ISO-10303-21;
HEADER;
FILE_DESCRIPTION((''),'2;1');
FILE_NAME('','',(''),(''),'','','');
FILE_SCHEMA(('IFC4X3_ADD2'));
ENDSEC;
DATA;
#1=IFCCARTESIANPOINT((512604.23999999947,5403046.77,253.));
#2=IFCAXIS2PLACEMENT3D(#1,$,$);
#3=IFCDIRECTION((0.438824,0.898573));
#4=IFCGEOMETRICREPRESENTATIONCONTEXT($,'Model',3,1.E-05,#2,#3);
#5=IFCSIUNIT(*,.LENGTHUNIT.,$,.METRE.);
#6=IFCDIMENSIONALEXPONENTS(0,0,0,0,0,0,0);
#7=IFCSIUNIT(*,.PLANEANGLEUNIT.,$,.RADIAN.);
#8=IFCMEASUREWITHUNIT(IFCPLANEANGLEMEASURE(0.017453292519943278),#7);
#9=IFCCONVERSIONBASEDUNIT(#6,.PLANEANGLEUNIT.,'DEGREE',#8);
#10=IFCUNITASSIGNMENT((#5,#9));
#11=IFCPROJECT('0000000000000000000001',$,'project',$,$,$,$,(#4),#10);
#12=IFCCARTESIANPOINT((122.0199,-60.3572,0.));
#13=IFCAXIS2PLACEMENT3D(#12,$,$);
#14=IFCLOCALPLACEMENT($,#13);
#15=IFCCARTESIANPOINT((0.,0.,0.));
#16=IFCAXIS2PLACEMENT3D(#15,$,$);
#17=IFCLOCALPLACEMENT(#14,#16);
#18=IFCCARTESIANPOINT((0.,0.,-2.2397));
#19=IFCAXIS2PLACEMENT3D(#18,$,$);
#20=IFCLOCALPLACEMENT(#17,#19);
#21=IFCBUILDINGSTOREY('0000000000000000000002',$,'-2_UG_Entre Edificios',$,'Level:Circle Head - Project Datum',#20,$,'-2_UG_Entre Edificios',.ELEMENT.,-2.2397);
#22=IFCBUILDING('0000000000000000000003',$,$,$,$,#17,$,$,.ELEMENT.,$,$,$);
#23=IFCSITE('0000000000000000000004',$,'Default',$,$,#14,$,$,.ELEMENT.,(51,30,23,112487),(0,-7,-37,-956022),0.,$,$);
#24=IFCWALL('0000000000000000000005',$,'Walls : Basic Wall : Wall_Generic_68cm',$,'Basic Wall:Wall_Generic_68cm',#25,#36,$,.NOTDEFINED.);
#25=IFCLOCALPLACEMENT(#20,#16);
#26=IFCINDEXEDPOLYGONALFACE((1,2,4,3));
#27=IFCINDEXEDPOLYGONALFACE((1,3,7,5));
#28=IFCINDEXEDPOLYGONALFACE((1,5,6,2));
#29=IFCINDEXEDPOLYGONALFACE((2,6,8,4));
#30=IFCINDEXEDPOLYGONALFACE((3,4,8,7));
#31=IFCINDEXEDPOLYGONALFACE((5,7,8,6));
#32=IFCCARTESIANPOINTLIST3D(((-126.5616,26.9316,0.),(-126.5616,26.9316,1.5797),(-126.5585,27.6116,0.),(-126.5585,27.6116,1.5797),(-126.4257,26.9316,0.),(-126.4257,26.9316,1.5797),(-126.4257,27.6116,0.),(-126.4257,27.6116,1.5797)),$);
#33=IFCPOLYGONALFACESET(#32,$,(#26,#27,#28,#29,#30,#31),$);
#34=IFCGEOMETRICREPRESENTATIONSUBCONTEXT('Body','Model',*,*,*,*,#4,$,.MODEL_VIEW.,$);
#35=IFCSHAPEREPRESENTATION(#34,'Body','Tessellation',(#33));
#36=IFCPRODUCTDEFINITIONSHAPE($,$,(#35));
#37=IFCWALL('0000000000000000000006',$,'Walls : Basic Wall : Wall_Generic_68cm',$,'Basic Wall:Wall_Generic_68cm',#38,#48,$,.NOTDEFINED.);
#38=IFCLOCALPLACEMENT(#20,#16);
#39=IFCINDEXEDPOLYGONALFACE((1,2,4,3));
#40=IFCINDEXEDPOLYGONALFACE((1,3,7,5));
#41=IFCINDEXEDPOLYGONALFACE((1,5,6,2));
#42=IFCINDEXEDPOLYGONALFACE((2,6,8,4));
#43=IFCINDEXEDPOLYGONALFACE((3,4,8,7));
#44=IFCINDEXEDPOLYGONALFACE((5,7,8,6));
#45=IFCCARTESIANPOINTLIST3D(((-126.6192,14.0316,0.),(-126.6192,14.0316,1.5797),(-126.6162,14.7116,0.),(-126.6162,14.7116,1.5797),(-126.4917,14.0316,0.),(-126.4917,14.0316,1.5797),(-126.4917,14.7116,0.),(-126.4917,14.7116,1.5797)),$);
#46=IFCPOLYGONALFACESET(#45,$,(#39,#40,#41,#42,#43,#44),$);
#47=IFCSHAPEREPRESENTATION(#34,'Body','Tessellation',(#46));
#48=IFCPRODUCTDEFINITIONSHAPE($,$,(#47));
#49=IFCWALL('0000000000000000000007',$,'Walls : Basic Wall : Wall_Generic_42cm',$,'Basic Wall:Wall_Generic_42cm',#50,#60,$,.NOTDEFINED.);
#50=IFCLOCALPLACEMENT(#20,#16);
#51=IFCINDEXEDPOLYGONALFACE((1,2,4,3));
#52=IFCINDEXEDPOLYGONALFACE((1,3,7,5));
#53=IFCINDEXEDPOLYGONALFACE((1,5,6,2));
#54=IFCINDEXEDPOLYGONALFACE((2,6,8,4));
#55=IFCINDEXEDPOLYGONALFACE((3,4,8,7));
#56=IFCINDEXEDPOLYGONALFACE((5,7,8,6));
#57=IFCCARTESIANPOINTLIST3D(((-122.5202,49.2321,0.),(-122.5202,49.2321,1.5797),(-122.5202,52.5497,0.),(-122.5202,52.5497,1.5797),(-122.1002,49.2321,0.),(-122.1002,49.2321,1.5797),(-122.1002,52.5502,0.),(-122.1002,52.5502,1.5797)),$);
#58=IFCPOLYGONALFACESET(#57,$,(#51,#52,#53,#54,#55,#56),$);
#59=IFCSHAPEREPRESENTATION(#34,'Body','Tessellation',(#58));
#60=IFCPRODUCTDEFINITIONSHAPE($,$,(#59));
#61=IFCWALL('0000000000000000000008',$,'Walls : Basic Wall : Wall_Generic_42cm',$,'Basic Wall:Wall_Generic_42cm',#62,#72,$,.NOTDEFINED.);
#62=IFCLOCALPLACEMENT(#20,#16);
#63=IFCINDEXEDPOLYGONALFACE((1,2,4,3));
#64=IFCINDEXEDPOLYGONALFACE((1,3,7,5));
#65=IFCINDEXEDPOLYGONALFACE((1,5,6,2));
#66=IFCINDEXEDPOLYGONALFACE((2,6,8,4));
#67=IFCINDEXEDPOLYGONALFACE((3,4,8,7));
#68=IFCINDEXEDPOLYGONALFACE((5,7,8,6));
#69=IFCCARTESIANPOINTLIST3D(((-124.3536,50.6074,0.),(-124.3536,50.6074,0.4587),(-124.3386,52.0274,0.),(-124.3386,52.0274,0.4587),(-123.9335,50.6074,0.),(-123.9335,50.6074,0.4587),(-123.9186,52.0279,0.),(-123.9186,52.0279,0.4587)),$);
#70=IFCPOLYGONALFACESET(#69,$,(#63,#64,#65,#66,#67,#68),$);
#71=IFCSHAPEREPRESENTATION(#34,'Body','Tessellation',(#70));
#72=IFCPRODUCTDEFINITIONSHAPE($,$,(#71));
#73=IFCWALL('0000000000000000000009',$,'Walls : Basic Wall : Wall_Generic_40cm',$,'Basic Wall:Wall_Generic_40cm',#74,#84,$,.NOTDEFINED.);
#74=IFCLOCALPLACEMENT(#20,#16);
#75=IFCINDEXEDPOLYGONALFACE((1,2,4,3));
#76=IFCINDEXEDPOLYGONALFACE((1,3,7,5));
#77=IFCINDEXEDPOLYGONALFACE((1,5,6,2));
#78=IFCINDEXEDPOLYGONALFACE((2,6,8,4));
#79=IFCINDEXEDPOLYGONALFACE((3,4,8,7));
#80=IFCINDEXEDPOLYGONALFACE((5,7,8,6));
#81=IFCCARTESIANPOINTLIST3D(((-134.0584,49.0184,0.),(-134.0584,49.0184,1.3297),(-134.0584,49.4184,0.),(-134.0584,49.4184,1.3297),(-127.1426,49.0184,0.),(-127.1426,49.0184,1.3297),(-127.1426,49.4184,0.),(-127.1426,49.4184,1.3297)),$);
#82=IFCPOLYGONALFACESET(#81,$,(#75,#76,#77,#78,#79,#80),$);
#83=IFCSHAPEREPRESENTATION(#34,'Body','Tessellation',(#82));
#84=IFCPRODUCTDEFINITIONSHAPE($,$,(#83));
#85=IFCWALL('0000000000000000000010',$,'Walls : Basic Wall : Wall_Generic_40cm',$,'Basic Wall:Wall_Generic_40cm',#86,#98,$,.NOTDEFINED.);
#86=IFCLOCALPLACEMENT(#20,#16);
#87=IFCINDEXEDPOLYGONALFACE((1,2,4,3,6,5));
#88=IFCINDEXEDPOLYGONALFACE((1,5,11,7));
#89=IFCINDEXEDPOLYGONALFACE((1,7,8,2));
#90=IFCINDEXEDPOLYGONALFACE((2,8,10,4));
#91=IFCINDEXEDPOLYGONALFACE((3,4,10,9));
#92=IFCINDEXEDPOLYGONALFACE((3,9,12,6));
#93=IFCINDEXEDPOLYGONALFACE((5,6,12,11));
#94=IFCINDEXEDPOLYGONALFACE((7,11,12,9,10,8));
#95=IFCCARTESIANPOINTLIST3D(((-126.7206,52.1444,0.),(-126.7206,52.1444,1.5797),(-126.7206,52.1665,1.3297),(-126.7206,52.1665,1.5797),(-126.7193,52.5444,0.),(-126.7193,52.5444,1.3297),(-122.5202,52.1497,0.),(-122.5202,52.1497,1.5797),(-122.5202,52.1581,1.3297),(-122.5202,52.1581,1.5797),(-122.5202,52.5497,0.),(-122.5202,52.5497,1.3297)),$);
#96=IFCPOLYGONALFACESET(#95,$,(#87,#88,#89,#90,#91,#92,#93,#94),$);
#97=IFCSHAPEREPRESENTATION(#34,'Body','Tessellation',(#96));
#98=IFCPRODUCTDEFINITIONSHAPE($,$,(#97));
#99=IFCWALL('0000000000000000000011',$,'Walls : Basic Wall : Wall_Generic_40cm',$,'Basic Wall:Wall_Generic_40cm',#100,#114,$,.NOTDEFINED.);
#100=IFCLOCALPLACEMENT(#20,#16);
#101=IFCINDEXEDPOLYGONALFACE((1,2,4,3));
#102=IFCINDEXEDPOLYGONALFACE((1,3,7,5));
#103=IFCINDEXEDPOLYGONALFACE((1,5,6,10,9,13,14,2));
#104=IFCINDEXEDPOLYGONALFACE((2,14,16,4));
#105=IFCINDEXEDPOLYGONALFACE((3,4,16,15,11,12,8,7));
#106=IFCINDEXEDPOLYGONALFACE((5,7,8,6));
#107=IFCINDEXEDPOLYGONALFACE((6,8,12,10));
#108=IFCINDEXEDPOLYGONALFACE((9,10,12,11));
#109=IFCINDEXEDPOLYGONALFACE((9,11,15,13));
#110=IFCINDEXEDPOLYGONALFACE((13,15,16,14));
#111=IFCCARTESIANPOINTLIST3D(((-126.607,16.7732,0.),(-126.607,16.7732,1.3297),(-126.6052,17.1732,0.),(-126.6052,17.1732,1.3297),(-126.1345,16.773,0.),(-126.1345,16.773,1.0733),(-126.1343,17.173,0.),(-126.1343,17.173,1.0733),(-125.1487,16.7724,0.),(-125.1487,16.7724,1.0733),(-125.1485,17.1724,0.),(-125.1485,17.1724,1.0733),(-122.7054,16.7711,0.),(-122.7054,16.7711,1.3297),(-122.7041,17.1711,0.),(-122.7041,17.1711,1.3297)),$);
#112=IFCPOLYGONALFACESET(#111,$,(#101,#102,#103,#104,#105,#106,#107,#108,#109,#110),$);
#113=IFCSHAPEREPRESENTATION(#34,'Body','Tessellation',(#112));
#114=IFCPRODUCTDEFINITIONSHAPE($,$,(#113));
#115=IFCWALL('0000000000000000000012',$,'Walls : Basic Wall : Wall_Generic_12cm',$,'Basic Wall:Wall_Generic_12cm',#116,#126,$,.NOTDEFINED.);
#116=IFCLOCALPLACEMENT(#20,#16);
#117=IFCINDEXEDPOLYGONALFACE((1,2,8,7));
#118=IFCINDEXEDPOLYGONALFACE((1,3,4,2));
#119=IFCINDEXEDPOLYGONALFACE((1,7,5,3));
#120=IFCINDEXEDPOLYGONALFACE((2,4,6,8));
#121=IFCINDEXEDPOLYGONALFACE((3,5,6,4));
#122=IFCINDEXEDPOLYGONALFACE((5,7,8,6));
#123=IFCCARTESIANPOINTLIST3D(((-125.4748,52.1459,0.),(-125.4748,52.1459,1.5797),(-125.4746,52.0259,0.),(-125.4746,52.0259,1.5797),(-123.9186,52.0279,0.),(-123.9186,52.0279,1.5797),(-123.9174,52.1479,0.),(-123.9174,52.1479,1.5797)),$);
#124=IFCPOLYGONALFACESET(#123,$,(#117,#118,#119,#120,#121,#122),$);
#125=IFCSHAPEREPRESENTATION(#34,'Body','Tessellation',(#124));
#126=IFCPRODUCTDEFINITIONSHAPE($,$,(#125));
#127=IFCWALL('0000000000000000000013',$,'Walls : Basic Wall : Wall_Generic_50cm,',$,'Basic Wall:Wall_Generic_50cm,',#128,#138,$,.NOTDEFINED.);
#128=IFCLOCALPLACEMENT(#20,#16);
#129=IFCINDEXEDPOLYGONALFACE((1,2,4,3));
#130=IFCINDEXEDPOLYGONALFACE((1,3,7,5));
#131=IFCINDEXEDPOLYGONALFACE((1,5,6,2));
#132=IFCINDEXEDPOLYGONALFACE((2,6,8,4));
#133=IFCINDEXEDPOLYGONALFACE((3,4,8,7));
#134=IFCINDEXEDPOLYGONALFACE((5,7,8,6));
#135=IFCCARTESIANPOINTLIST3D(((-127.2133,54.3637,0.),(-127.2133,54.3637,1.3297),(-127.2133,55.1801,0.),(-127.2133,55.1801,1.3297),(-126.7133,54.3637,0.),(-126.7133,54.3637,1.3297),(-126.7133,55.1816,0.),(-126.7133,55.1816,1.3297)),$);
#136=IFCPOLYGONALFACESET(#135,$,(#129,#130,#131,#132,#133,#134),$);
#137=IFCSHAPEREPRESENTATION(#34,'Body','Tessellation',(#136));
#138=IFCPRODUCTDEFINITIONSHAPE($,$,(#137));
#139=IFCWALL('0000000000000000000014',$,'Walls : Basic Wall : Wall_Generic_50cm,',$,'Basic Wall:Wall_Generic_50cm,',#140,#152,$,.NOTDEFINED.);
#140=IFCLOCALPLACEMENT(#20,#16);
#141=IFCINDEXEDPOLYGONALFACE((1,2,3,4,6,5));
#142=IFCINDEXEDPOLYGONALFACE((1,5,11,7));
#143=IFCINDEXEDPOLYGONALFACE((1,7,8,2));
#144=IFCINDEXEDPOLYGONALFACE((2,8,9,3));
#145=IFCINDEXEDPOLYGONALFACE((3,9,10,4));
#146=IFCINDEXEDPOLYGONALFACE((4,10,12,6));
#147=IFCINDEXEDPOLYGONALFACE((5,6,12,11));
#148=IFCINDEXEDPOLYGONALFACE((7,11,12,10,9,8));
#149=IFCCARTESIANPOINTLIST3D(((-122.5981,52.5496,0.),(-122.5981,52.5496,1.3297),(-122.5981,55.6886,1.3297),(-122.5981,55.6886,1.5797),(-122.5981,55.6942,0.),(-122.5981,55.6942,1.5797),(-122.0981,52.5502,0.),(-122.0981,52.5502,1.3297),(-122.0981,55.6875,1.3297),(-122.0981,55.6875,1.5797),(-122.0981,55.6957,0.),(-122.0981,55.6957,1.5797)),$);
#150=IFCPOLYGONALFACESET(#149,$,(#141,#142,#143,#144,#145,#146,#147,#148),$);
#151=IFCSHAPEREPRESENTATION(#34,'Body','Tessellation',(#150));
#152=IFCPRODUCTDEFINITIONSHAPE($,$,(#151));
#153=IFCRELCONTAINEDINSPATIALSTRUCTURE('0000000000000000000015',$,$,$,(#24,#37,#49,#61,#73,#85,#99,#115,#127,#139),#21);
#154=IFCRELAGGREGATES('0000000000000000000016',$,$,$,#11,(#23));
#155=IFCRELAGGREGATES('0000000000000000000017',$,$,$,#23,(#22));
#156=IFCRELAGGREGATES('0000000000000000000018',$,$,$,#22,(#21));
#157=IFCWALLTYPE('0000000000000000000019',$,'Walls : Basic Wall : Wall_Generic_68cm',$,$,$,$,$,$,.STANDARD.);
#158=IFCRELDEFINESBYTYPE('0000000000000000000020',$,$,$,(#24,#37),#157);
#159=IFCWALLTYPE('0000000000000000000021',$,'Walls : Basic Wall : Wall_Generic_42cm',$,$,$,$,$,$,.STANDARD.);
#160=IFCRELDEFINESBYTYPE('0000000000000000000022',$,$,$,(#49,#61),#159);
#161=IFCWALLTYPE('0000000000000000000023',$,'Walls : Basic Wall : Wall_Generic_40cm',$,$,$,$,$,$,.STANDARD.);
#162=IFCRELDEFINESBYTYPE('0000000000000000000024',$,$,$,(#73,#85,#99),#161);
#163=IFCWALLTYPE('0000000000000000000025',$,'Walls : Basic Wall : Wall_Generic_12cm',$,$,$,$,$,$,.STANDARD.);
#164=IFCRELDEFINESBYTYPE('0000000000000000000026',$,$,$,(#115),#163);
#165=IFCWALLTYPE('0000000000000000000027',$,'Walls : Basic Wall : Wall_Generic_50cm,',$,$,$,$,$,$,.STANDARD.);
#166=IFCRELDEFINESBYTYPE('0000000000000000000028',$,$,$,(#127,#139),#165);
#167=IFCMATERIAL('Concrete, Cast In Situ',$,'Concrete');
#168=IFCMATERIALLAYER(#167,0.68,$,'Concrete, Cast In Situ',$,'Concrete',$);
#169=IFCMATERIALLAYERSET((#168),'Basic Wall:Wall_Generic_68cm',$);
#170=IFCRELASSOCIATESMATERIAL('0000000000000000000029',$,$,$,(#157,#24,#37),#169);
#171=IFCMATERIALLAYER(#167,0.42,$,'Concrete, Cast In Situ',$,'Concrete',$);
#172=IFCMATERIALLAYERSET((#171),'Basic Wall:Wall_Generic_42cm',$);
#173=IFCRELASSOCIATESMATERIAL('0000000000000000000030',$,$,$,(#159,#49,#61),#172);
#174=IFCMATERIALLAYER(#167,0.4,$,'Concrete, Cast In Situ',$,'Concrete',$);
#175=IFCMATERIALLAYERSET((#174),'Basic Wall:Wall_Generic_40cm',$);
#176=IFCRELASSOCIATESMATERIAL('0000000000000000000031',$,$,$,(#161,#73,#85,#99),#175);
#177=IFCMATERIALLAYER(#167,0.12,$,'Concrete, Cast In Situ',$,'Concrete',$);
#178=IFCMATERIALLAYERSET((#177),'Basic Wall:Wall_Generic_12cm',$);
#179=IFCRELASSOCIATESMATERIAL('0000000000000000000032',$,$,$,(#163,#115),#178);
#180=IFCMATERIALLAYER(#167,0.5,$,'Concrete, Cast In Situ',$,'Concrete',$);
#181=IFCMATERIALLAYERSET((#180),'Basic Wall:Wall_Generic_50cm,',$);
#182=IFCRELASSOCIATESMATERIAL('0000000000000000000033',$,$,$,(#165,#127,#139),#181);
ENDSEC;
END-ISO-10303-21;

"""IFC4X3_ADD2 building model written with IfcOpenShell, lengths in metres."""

from ifc_helpers import new_model, entity, si_unit, converted_unit, direction, frame, frame_2d, origin, place, context, subcontext, project, spatial, polyline, rectangle, outline, extrude, clip, halfspace, bounded_halfspace, material, layer, layer_set, type_object, element, save


model = new_model("IFC4X3_ADD2")

# Units and contexts
model_context = context("Model", 3, precision=1e-05, world=frame((512604.23999999947, 5403046.77, 253.0)), true_north=direction((0.438824, 0.898573)))
body_context = subcontext(model_context, "Body", "Model", "MODEL_VIEW")
ifc_project = project(units=[si_unit("LENGTHUNIT", "METRE"), converted_unit("PLANEANGLEUNIT", "DEGREE", entity("IfcPlaneAngleMeasure", 0.017453292519943278), si_unit("PLANEANGLEUNIT", "RADIAN"), dimensions=[0, 0, 0, 0, 0, 0, 0])], contexts=[model_context])

# Site, building, storey
site_placement = place(None, frame((122.0199, -60.3572, 0.0)))
site = spatial("IfcSite", under=ifc_project, at=site_placement, Name="Default", CompositionType="ELEMENT", RefLatitude=(51, 30, 23, 112487), RefLongitude=(0, -7, -37, -956022), RefElevation=0.0)
building_placement = place(site_placement, origin())
building = spatial("IfcBuilding", under=site, at=building_placement, CompositionType="ELEMENT")
storey_placement = place(building_placement, frame((0.0, 0.0, -2.2397)))
storey = spatial("IfcBuildingStorey", under=building, at=storey_placement, Name="-2_UG_Entre Edificios", ObjectType="Level:Circle Head - Project Datum", LongName="-2_UG_Entre Edificios", CompositionType="ELEMENT", Elevation=-2.2397)

# Walls
ifc_material_1 = material(Name="Concrete, Cast In Situ", Category="Concrete")
ifc_layer_1 = layer(ifc_material_1, 0.68, Name="Concrete, Cast In Situ", Category="Concrete")
ifc_layer_set_1 = layer_set([ifc_layer_1], Name="Basic Wall:Wall_Generic_68cm")
wall_type_1 = type_object("IfcWallType", Name="Walls : Basic Wall : Wall_Generic_68cm", PredefinedType="STANDARD", material=ifc_layer_set_1)
wall_1_placement = place(storey_placement, frame((-126.5616, 27.2716, 0.0)))
element("IfcWall", 1, at=wall_1_placement, inside=storey, type_object=wall_type_1, material=ifc_layer_set_1, Name="Walls : Basic Wall : Wall_Generic_68cm", ObjectType="Basic Wall:Wall_Generic_68cm", PredefinedType="NOTDEFINED", context=body_context, shape_type="Clipping", body=[
    clip(extrude(outline(polyline([(0.1359, -0.34), (0.1359, 0.34), (0.003, 0.34), (0.0, -0.34), (0.1359, -0.34)])), origin(), (0.0, 0.0, 1.0), 1.5797), halfspace(frame((0.0, 0.0, -1.0603)), True)),
])
wall_2_placement = place(storey_placement, frame((-126.6192, 14.3716, 0.0)))
element("IfcWall", 2, at=wall_2_placement, inside=storey, type_object=wall_type_1, material=ifc_layer_set_1, Name="Walls : Basic Wall : Wall_Generic_68cm", ObjectType="Basic Wall:Wall_Generic_68cm", PredefinedType="NOTDEFINED", context=body_context, shape_type="Clipping", body=[
    clip(extrude(outline(polyline([(0.1275, -0.34), (0.1275, 0.34), (0.003, 0.34), (0.0, -0.34), (0.1275, -0.34)])), origin(), (0.0, 0.0, 1.0), 1.5797), halfspace(frame((0.0, 0.0, -1.0603)), True)),
])
ifc_layer_2 = layer(ifc_material_1, 0.42, Name="Concrete, Cast In Situ", Category="Concrete")
ifc_layer_set_2 = layer_set([ifc_layer_2], Name="Basic Wall:Wall_Generic_42cm")
wall_type_2 = type_object("IfcWallType", Name="Walls : Basic Wall : Wall_Generic_42cm", PredefinedType="STANDARD", material=ifc_layer_set_2)
wall_3_placement = place(storey_placement, frame((-122.3102, 49.2321, 0.0), z_axis=(0.0, 0.0, 1.0), x_axis=(0.0, 1.0, 0.0)))
element("IfcWall", 3, at=wall_3_placement, inside=storey, type_object=wall_type_2, material=ifc_layer_set_2, Name="Walls : Basic Wall : Wall_Generic_42cm", ObjectType="Basic Wall:Wall_Generic_42cm", PredefinedType="NOTDEFINED", context=body_context, shape_type="Clipping", body=[
    clip(extrude(outline(polyline([(3.3182, -0.21), (3.3176, 0.21), (2.9176, 0.21), (0.0, 0.21), (0.0, -0.2064), (0.0, -0.21), (3.3182, -0.21)])), origin(), (0.0, 0.0, 1.0), 1.5797), halfspace(frame((0.0, 0.0, -1.0603)), True)),
])
wall_4_placement = place(storey_placement, frame((-124.1286, 52.0301, 0.0), z_axis=(0.0, 0.0, 1.0), x_axis=(-0.010506, -0.999945, 0.0)))
element("IfcWall", 4, at=wall_4_placement, inside=storey, type_object=wall_type_2, material=ifc_layer_set_2, Name="Walls : Basic Wall : Wall_Generic_42cm", ObjectType="Basic Wall:Wall_Generic_42cm", PredefinedType="NOTDEFINED", context=body_context, shape_type="Clipping", body=[
    clip(extrude(outline(polyline([(1.425, -0.21), (1.4206, 0.21), (1.1142, 0.21), (0.0, 0.21), (0.0049, -0.21), (1.165, -0.21), (1.425, -0.21)])), origin(), (0.0, 0.0, 1.0), 0.4587), halfspace(frame((0.0, 0.0, -1.0603)), True)),
])
ifc_layer_3 = layer(ifc_material_1, 0.4, Name="Concrete, Cast In Situ", Category="Concrete")
ifc_layer_set_3 = layer_set([ifc_layer_3], Name="Basic Wall:Wall_Generic_40cm")
wall_type_3 = type_object("IfcWallType", Name="Walls : Basic Wall : Wall_Generic_40cm", PredefinedType="STANDARD", material=ifc_layer_set_3)
wall_5_placement = place(storey_placement, frame((-127.1426, 49.2184, 0.0), z_axis=(0.0, 0.0, 1.0), x_axis=(-1.0, 0.0, 0.0)))
element("IfcWall", 5, at=wall_5_placement, inside=storey, type_object=wall_type_3, material=ifc_layer_set_3, Name="Walls : Basic Wall : Wall_Generic_40cm", ObjectType="Basic Wall:Wall_Generic_40cm", PredefinedType="NOTDEFINED", context=body_context, shape_type="SweptSolid", body=[
    extrude(rectangle(XDim=0.4, YDim=6.9158, at=frame_2d((0.0, 0.0), x_axis=(1.0, 0.0))), frame((3.4579, 0.0, 0.0), z_axis=(0.0, 0.0, 1.0), x_axis=(0.0, 1.0, 0.0)), (0.0, 0.0, 1.0), 1.3297),
])
wall_6_placement = place(storey_placement, frame((-126.7209, 52.3444, 0.0), z_axis=(0.0, 0.0, 1.0), x_axis=(0.999999, 0.001273, 0.0)))
element("IfcWall", 6, at=wall_6_placement, inside=storey, type_object=wall_type_3, material=ifc_layer_set_3, Name="Walls : Basic Wall : Wall_Generic_40cm", ObjectType="Basic Wall:Wall_Generic_40cm", PredefinedType="NOTDEFINED", context=body_context, shape_type="Clipping", body=[
    clip(clip(extrude(outline(polyline([(0.0018, 0.2), (0.0, -0.2), (1.2459, -0.2), (2.8033, -0.2), (3.0403, -0.2), (4.2005, -0.2), (4.201, 0.2), (4.1231, 0.2), (0.0018, 0.2)])), origin(), (0.0, 0.0, 1.0), 1.5797), bounded_halfspace(frame((4.2005, -0.1916, 1.3297), z_axis=(0.0, 0.0, -1.0), x_axis=(0.999999, -0.001273, 0.0)), True, frame((4.2005, -0.1916, 1.3297)), polyline([(0.0, 0.0), (0.0005, 0.3916), (-0.0774, 0.3916), (-4.1986, 0.3916), (-4.2004, 0.0138), (-2.9647, 0.0097), (0.0, 0.0)]))), halfspace(frame((0.0, 0.0, -1.0603)), True)),
])

# Wall, opening
wall_7_placement = place(storey_placement, frame((-126.6069, 16.9732, 0.0), z_axis=(0.0, 0.0, 1.0), x_axis=(1.0, -0.000544, 0.0)))
wall_7 = element("IfcWall", 7, at=wall_7_placement, inside=storey, type_object=wall_type_3, material=ifc_layer_set_3, Name="Walls : Basic Wall : Wall_Generic_40cm", ObjectType="Basic Wall:Wall_Generic_40cm", PredefinedType="NOTDEFINED", context=body_context, shape_type="Clipping", body=[
    clip(clip(extrude(outline(polyline([(0.0, -0.2), (3.9016, -0.2), (3.9027, 0.2), (0.0016, 0.2), (0.0, -0.2)])), origin(), (0.0, 0.0, 1.0), 1.3297), bounded_halfspace(frame((0.0, -0.2, 1.3297), z_axis=(0.0, 0.0, -1.0), x_axis=(1.0, 0.000544, 0.0)), True, frame((0.0, -0.2, 1.3297)), polyline([(0.0, 0.0), (3.9016, 0.0), (3.9027, 0.4), (0.0016, 0.4), (0.0, 0.0)]))), halfspace(frame((0.0, 0.0, -1.0603)), True)),
])
opening_placement = place(wall_7_placement, frame((126.6161, -16.9044, -1.0603), z_axis=(0.0, 0.0, 1.0), x_axis=(1.0, 0.000544, 0.0)))
element("IfcOpeningElement", 8, at=opening_placement, cuts=wall_7, PredefinedType="OPENING", context=body_context, shape_type="SweptSolid", body=[
    extrude(rectangle(XDim=2.1336, YDim=0.9858, at=frame_2d((0.0, 0.0), x_axis=(0.0, 1.0))), frame((-125.6416, 16.7727, 1.0668), z_axis=(0.000544, 1.0, 0.0), x_axis=(1.0, -0.000544, 0.0)), (0.0, 0.0, 1.0), 0.4),
])

# Walls
ifc_layer_4 = layer(ifc_material_1, 0.12, Name="Concrete, Cast In Situ", Category="Concrete")
ifc_layer_set_4 = layer_set([ifc_layer_4], Name="Basic Wall:Wall_Generic_12cm")
wall_type_4 = type_object("IfcWallType", Name="Walls : Basic Wall : Wall_Generic_12cm", PredefinedType="STANDARD", material=ifc_layer_set_4)
wall_8_placement = place(storey_placement, frame((-125.4747, 52.0859, 0.0), z_axis=(0.0, 0.0, 1.0), x_axis=(0.999999, 0.001273, 0.0)))
element("IfcWall", 9, at=wall_8_placement, inside=storey, type_object=wall_type_4, material=ifc_layer_set_4, Name="Walls : Basic Wall : Wall_Generic_12cm", ObjectType="Basic Wall:Wall_Generic_12cm", PredefinedType="NOTDEFINED", context=body_context, shape_type="Clipping", body=[
    clip(extrude(outline(polyline([(1.556, -0.06), (1.5574, 0.06), (0.0, 0.06), (0.0, -0.06), (1.136, -0.06), (1.556, -0.06)])), origin(), (0.0, 0.0, 1.0), 1.5797), halfspace(frame((0.0, 0.0, -1.0603)), True)),
])
ifc_layer_5 = layer(ifc_material_1, 0.5, Name="Concrete, Cast In Situ", Category="Concrete")
ifc_layer_set_5 = layer_set([ifc_layer_5], Name="Basic Wall:Wall_Generic_50cm,")
wall_type_5 = type_object("IfcWallType", Name="Walls : Basic Wall : Wall_Generic_50cm,", PredefinedType="STANDARD", material=ifc_layer_set_5)
wall_9_placement = place(storey_placement, frame((-126.9633, 55.1816, 0.0), z_axis=(0.0, 0.0, 1.0), x_axis=(0.0, -1.0, 0.0)))
element("IfcWall", 10, at=wall_9_placement, inside=storey, type_object=wall_type_5, material=ifc_layer_set_5, Name="Walls : Basic Wall : Wall_Generic_50cm,", ObjectType="Basic Wall:Wall_Generic_50cm,", PredefinedType="NOTDEFINED", context=body_context, shape_type="Clipping", body=[
    clip(clip(extrude(outline(polyline([(0.818, -0.25), (0.818, 0.25), (0.0, 0.25), (0.0015, -0.25), (0.818, -0.25)])), origin(), (0.0, 0.0, 1.0), 1.3297), bounded_halfspace(frame((0.0015, -0.25, 1.3297), z_axis=(0.0, 0.0, -1.0), x_axis=(0.0, 1.0, 0.0)), True, frame((0.0015, -0.25, 1.3297)), polyline([(0.0, 0.0), (0.8165, 0.0), (0.8165, 0.5), (-0.0015, 0.5), (0.0, 0.0)]))), halfspace(frame((0.0, 0.0, -1.0603)), True)),
])
wall_10_placement = place(storey_placement, frame((-122.3481, 55.6957, 0.0), z_axis=(0.0, 0.0, 1.0), x_axis=(0.0, -1.0, 0.0)))
element("IfcWall", 11, at=wall_10_placement, inside=storey, type_object=wall_type_5, material=ifc_layer_set_5, Name="Walls : Basic Wall : Wall_Generic_50cm,", ObjectType="Basic Wall:Wall_Generic_50cm,", PredefinedType="NOTDEFINED", context=body_context, shape_type="Clipping", body=[
    clip(clip(extrude(outline(polyline([(3.1461, -0.25), (3.146, -0.1721), (3.1455, 0.2479), (3.1455, 0.25), (0.0, 0.25), (0.0015, -0.25), (3.1461, -0.25)])), origin(), (0.0, 0.0, 1.0), 1.5797), bounded_halfspace(frame((0.0071, -0.25, 1.3297), z_axis=(0.0, 0.0, -1.0), x_axis=(0.0, 1.0, 0.0)), True, frame((0.0071, -0.25, 1.3297)), polyline([(0.0, 0.0), (0.4944, 0.0), (3.139, 0.0), (3.1389, 0.0779), (3.1384, 0.5), (0.0011, 0.5), (0.0, 0.0)]))), halfspace(frame((0.0, 0.0, -1.0603)), True)),
])

save(model, "model.ifc")
